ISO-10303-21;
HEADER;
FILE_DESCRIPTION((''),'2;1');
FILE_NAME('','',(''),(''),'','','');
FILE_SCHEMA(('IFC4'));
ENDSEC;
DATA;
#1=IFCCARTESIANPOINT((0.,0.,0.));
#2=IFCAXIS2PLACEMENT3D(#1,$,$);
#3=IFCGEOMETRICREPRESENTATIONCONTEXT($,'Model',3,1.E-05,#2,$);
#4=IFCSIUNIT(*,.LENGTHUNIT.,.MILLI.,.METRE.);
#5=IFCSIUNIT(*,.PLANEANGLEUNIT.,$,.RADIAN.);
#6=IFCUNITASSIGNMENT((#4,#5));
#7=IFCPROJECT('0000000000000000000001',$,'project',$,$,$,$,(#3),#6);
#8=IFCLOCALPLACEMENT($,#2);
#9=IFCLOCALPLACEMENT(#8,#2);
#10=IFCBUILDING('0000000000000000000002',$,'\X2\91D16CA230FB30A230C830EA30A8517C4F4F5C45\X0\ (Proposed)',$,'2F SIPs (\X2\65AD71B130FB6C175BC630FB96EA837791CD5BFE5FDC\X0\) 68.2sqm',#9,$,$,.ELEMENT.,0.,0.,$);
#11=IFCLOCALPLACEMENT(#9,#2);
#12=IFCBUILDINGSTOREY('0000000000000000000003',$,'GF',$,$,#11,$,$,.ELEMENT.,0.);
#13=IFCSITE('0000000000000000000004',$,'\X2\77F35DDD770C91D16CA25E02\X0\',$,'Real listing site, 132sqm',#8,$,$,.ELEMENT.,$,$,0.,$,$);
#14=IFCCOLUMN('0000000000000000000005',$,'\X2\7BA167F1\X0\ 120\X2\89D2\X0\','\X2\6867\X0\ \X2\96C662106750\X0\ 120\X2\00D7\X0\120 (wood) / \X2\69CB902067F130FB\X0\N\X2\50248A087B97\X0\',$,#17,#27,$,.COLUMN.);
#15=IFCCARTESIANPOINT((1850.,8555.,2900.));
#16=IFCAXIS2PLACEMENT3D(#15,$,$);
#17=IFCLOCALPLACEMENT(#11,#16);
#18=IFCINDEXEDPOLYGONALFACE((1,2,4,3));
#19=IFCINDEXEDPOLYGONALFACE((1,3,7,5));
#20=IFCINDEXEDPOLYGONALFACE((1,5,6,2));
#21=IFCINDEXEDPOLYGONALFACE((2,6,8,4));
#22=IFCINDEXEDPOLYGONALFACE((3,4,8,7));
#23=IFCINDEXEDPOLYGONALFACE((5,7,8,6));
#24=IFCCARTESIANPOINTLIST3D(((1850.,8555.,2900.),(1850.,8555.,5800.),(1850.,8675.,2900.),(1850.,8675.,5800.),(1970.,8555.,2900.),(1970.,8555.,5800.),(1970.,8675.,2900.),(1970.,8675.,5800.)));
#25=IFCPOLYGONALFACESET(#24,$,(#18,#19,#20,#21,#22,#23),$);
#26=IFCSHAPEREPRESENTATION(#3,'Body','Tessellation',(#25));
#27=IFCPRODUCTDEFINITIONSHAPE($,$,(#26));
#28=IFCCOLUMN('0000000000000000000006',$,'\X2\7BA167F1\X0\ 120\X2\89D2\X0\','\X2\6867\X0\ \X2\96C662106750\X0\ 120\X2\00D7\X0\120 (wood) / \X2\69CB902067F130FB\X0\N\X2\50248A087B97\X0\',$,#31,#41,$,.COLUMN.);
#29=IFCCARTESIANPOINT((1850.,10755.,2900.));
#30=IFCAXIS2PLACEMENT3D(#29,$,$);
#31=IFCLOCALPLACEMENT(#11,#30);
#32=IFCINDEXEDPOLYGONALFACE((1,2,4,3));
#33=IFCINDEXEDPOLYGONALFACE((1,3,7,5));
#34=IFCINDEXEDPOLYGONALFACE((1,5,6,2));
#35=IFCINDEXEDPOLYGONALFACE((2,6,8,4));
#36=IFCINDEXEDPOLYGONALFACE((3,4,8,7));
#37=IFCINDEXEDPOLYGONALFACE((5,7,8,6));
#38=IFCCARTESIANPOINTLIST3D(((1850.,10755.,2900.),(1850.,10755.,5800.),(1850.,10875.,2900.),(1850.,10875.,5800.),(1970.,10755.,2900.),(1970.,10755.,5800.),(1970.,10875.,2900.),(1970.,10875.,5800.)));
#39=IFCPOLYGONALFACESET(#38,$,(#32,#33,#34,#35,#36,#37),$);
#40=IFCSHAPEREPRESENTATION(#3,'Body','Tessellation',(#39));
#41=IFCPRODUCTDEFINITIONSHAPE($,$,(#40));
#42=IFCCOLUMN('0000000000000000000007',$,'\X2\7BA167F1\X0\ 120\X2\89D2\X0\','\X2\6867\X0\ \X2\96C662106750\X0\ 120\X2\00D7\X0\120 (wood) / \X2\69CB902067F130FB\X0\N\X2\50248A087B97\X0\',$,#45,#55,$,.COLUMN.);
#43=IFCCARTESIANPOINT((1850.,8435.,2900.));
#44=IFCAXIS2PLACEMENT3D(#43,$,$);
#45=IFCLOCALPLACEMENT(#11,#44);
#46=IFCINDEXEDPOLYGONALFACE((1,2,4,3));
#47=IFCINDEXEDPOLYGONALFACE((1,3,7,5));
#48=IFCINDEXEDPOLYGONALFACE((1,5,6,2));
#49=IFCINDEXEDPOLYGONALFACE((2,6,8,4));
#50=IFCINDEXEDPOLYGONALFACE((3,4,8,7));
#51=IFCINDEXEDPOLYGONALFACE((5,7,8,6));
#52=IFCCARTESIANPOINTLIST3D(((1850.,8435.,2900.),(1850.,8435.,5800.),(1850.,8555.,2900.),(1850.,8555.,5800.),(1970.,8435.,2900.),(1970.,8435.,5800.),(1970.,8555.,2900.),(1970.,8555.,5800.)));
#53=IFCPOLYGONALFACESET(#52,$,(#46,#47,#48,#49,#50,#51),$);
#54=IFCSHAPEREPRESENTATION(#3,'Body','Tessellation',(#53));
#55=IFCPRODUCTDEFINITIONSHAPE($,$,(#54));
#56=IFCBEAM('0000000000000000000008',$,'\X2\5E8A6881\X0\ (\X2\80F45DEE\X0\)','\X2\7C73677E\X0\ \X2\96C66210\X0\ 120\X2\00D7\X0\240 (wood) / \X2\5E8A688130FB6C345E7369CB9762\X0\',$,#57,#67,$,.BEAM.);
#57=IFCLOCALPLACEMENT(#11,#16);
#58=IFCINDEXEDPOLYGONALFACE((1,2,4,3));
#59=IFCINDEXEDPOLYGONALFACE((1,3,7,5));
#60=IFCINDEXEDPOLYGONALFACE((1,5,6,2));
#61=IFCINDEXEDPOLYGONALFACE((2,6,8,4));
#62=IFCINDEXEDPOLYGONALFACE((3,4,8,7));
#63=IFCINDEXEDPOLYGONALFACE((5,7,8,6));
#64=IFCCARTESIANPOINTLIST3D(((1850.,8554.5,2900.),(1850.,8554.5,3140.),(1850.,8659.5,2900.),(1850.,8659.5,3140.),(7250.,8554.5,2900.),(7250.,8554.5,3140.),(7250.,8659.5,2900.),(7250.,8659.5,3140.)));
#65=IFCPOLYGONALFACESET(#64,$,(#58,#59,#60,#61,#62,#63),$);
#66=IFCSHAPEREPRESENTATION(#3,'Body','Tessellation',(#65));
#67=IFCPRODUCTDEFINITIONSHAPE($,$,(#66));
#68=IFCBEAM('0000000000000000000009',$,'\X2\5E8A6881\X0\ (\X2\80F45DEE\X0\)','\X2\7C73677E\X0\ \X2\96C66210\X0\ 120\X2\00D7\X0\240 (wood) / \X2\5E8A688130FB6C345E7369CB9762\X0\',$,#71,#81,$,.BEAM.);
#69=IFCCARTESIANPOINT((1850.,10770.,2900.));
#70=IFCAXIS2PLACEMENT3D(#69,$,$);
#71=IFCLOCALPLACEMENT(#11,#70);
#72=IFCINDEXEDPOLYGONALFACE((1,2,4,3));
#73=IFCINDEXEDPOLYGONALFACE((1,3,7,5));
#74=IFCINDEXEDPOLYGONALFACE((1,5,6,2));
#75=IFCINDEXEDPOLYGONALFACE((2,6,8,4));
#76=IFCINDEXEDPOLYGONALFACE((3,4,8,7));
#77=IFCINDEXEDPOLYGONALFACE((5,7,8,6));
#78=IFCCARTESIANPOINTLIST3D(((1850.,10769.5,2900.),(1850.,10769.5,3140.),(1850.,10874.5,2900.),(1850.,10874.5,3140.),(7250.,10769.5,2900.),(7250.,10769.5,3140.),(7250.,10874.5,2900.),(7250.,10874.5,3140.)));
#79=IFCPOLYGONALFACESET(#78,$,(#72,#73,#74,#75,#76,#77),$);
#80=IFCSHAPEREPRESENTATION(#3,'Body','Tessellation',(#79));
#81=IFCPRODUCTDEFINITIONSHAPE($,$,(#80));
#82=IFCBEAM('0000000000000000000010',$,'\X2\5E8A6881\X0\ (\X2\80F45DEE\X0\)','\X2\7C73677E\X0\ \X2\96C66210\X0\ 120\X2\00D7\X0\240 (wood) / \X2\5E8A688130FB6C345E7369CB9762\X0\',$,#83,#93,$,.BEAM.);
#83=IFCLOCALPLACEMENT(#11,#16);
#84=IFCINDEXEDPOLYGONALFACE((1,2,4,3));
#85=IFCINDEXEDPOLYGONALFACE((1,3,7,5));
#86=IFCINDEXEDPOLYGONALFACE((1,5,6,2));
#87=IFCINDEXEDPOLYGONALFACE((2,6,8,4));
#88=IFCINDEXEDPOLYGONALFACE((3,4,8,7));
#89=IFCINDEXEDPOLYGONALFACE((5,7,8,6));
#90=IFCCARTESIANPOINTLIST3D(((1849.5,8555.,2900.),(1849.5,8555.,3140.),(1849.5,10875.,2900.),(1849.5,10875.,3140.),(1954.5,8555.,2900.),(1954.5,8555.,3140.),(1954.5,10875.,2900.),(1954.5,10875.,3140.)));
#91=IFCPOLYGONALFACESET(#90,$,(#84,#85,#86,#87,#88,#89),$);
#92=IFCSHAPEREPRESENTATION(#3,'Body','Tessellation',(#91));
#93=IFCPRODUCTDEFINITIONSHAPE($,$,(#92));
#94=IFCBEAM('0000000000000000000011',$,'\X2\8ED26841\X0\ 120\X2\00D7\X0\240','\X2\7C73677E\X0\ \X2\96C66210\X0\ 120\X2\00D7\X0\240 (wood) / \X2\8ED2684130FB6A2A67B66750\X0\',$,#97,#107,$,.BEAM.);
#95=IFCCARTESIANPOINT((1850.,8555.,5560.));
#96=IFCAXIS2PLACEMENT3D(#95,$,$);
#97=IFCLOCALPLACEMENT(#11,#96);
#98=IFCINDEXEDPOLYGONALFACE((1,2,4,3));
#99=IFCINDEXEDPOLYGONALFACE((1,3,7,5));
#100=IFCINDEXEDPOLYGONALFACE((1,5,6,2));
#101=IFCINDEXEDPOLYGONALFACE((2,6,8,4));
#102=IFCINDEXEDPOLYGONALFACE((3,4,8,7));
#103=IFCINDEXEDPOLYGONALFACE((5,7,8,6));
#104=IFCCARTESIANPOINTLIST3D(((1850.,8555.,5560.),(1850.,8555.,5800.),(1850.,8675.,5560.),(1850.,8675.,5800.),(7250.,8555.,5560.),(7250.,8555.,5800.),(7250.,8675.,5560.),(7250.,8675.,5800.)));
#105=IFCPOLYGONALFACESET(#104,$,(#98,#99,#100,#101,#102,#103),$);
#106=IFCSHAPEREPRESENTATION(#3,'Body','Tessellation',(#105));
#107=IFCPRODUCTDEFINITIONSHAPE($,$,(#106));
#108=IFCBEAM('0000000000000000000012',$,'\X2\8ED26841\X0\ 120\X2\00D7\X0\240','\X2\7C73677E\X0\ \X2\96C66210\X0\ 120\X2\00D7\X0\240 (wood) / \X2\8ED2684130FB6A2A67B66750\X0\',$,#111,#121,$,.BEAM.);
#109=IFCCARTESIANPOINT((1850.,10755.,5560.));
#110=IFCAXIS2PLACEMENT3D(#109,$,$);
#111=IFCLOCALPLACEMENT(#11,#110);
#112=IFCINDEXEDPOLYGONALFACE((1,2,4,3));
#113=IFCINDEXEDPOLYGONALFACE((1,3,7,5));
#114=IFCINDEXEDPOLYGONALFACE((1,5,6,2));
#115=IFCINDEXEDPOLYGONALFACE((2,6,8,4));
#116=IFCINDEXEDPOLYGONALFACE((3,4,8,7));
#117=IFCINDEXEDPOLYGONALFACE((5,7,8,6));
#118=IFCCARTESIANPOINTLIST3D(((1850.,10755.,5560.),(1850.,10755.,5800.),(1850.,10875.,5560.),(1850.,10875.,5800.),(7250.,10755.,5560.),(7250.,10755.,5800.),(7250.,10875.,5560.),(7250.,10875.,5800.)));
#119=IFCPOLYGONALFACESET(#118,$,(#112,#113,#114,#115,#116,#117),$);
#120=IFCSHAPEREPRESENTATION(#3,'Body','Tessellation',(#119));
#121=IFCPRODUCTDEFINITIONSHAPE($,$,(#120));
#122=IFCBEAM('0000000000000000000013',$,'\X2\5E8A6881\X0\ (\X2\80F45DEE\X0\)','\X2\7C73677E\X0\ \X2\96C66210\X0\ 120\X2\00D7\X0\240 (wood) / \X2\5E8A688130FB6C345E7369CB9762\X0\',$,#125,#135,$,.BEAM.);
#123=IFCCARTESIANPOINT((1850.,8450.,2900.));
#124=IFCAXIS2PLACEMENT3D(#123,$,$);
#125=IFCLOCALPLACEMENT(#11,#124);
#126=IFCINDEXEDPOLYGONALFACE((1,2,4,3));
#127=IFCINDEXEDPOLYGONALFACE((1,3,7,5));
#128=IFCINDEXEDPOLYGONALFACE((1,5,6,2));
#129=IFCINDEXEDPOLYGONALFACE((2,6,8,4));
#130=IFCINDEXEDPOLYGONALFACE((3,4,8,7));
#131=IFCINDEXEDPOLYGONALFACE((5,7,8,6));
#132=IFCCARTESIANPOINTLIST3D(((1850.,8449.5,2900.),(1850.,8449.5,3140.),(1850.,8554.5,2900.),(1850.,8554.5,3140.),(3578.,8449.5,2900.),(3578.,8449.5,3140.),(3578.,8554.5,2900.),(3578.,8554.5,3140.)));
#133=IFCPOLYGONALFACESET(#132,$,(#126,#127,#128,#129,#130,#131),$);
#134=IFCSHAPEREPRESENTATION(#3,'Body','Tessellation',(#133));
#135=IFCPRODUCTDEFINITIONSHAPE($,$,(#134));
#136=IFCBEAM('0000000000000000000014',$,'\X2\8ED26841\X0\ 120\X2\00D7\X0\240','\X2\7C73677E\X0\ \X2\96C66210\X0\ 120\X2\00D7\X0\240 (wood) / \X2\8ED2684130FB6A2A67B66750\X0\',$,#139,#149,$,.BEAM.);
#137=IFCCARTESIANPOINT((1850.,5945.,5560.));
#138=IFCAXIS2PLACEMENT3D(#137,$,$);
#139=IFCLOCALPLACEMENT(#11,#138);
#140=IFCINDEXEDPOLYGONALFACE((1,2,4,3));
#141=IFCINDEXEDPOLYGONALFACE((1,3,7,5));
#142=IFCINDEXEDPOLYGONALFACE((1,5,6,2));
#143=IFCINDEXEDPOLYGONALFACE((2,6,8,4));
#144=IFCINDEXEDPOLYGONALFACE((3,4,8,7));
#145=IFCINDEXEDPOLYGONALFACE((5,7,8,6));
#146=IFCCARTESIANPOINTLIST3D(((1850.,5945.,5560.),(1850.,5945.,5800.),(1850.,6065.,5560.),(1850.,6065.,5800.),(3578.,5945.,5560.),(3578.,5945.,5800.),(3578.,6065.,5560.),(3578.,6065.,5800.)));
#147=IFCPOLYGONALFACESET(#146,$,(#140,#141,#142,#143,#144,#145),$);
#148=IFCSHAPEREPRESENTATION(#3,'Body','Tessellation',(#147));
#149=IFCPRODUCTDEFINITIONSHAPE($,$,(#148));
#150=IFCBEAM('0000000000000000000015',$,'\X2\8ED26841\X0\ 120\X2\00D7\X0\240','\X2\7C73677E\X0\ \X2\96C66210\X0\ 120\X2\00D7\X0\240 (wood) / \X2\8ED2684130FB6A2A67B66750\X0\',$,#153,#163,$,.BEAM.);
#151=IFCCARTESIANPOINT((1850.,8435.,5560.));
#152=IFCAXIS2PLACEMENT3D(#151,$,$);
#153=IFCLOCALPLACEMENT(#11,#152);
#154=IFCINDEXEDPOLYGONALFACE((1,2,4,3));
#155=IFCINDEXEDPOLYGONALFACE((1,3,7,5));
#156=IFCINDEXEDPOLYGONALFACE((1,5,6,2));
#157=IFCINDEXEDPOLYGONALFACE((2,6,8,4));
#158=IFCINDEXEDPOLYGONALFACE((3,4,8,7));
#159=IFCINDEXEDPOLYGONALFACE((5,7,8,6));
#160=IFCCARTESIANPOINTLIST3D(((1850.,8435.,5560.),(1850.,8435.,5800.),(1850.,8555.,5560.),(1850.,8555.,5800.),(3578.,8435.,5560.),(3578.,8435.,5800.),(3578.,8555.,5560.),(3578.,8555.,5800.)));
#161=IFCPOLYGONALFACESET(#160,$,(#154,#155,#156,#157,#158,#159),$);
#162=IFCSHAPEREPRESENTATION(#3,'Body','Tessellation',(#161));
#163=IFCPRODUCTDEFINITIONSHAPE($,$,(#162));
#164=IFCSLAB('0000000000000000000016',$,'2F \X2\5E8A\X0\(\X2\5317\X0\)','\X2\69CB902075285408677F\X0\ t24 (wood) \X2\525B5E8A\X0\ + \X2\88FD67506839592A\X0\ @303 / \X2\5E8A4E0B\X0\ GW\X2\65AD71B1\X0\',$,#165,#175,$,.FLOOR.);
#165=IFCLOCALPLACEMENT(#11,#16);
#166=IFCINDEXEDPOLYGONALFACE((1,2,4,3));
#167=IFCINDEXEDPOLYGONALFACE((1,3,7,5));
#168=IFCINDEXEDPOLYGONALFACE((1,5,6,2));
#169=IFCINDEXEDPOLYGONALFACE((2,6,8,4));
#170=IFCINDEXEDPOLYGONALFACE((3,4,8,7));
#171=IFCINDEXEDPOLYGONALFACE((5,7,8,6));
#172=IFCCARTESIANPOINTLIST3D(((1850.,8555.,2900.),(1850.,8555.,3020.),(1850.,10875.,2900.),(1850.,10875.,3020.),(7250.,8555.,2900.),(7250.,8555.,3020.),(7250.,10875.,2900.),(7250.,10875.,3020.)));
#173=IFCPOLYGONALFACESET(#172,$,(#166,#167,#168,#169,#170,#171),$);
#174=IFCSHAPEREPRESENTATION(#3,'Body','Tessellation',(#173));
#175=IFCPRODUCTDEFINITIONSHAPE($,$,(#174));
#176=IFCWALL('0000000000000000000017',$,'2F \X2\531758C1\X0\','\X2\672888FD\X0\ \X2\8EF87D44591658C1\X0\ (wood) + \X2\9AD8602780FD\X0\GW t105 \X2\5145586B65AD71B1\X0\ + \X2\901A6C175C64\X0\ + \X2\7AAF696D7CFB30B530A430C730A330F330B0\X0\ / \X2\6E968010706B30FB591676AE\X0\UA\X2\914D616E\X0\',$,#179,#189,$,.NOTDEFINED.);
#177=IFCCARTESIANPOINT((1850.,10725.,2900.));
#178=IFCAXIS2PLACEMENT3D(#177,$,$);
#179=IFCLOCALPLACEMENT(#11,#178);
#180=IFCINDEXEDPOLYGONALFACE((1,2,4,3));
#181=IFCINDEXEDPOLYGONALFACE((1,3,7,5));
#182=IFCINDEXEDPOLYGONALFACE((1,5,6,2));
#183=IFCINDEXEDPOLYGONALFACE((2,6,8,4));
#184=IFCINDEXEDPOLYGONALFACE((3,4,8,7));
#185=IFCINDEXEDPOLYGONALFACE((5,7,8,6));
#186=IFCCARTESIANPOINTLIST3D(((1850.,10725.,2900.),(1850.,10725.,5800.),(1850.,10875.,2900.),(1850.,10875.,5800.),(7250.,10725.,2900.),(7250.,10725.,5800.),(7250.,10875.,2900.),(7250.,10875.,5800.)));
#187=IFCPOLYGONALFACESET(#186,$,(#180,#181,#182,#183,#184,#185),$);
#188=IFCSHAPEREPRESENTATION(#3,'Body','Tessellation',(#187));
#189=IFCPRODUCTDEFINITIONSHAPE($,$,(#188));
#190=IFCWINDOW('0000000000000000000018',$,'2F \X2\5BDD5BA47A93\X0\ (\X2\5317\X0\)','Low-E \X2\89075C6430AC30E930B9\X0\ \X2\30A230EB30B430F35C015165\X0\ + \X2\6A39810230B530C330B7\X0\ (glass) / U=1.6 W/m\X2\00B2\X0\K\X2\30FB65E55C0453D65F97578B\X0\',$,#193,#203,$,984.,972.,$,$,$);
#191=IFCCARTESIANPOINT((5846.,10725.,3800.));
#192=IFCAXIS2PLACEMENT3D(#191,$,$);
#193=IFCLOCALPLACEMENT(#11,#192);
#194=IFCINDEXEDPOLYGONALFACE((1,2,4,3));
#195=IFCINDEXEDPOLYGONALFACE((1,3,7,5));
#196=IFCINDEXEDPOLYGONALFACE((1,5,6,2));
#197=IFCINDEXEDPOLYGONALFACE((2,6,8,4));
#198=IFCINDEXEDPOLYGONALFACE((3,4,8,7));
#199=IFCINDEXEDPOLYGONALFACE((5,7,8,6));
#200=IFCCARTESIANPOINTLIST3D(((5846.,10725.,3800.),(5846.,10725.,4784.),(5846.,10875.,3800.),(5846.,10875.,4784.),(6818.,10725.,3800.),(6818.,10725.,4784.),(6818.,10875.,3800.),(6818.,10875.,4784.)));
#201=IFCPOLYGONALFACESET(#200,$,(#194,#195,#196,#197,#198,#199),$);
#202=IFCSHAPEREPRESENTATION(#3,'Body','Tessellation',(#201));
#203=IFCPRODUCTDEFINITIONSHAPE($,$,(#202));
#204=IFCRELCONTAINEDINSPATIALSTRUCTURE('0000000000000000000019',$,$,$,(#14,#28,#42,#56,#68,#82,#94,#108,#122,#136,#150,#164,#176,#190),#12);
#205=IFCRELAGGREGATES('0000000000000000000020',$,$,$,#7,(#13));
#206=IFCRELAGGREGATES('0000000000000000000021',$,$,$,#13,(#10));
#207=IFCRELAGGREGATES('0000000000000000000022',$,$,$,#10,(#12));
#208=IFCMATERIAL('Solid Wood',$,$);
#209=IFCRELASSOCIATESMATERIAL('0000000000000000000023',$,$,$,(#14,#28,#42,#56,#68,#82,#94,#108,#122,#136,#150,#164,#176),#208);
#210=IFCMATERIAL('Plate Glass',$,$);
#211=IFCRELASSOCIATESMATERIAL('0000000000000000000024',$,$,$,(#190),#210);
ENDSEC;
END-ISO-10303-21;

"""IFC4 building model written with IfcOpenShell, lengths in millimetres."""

from ifc_helpers import new_model, si_unit, frame, frame_2d, origin, place, context, project, spatial, rectangle, extrude, material, element, fill, save


model = new_model("IFC4")

# Units and contexts
model_context = context("Model", 3, precision=1e-05, world=origin())
ifc_project = project(units=[si_unit("LENGTHUNIT", "METRE", prefix="MILLI"), si_unit("PLANEANGLEUNIT", "RADIAN")], contexts=[model_context])

# Site, building, storey
site_placement = place(None, origin())
site = spatial("IfcSite", under=ifc_project, at=site_placement, Name="石川県金沢市", ObjectType="Real listing site, 132sqm", CompositionType="ELEMENT", RefElevation=0.0)
building_placement = place(site_placement, origin())
building = spatial("IfcBuilding", under=site, at=building_placement, Name="金沢・アトリエ兼住居 (Proposed)", ObjectType="2F SIPs (断熱・気密・雪荷重対応) 68.2sqm", CompositionType="ELEMENT", ElevationOfRefHeight=0.0, ElevationOfTerrain=0.0)
storey_placement = place(building_placement, origin())
storey = spatial("IfcBuildingStorey", under=building, at=storey_placement, Name="GF", CompositionType="ELEMENT", Elevation=0.0)

# Columns
ifc_material_1 = material(Name="Solid Wood")
column_1_placement = place(storey_placement, frame((1850.0, 8555.0, 2900.0)))
element("IfcColumn", 1, at=column_1_placement, inside=storey, material=ifc_material_1, Name="管柱 120角", Description="桧 集成材 120×120 (wood) / 構造柱・N値計算", PredefinedType="COLUMN", context=model_context, shape_type="SweptSolid", body=[
    extrude(rectangle(XDim=120.0, YDim=120.0, at=frame_2d((60.0, 60.0))), frame((1850.0, 8555.0, 2900.0)), (0.0, 0.0, 1.0), 2900.0),
])
column_2_placement = place(storey_placement, frame((1850.0, 10755.0, 2900.0)))
element("IfcColumn", 2, at=column_2_placement, inside=storey, material=ifc_material_1, Name="管柱 120角", Description="桧 集成材 120×120 (wood) / 構造柱・N値計算", PredefinedType="COLUMN", context=model_context, shape_type="SweptSolid", body=[
    extrude(rectangle(XDim=120.0, YDim=120.0, at=frame_2d((60.0, 60.0))), frame((1850.0, 10755.0, 2900.0)), (0.0, 0.0, 1.0), 2900.0),
])
column_3_placement = place(storey_placement, frame((1850.0, 8435.0, 2900.0)))
element("IfcColumn", 3, at=column_3_placement, inside=storey, material=ifc_material_1, Name="管柱 120角", Description="桧 集成材 120×120 (wood) / 構造柱・N値計算", PredefinedType="COLUMN", context=model_context, shape_type="SweptSolid", body=[
    extrude(rectangle(XDim=120.0, YDim=120.0, at=frame_2d((60.0, 60.0))), frame((1850.0, 8435.0, 2900.0)), (0.0, 0.0, 1.0), 2900.0),
])

# Beams
beam_1_placement = place(storey_placement, frame((1850.0, 8555.0, 2900.0)))
element("IfcBeam", 4, at=beam_1_placement, inside=storey, material=ifc_material_1, Name="床梁 (胴差)", Description="米松 集成 120×240 (wood) / 床梁・水平構面", PredefinedType="BEAM", context=model_context, shape_type="SweptSolid", body=[
    extrude(rectangle(XDim=5400.0, YDim=105.0, at=frame_2d((2700.0, 52.0))), frame((1850.0, 8555.0, 2900.0)), (0.0, 0.0, 1.0), 240.0),
])
beam_2_placement = place(storey_placement, frame((1850.0, 10770.0, 2900.0)))
element("IfcBeam", 5, at=beam_2_placement, inside=storey, material=ifc_material_1, Name="床梁 (胴差)", Description="米松 集成 120×240 (wood) / 床梁・水平構面", PredefinedType="BEAM", context=model_context, shape_type="SweptSolid", body=[
    extrude(rectangle(XDim=5400.0, YDim=105.0, at=frame_2d((2700.0, 52.0))), frame((1850.0, 10770.0, 2900.0)), (0.0, 0.0, 1.0), 240.0),
])
beam_3_placement = place(storey_placement, frame((1850.0, 8555.0, 2900.0)))
element("IfcBeam", 6, at=beam_3_placement, inside=storey, material=ifc_material_1, Name="床梁 (胴差)", Description="米松 集成 120×240 (wood) / 床梁・水平構面", PredefinedType="BEAM", context=model_context, shape_type="SweptSolid", body=[
    extrude(rectangle(XDim=105.0, YDim=2320.0, at=frame_2d((52.0, 1160.0))), frame((1850.0, 8555.0, 2900.0)), (0.0, 0.0, 1.0), 240.0),
])
beam_4_placement = place(storey_placement, frame((1850.0, 8555.0, 5560.0)))
element("IfcBeam", 7, at=beam_4_placement, inside=storey, material=ifc_material_1, Name="軒桁 120×240", Description="米松 集成 120×240 (wood) / 軒桁・横架材", PredefinedType="BEAM", context=model_context, shape_type="SweptSolid", body=[
    extrude(rectangle(XDim=5400.0, YDim=120.0, at=frame_2d((2700.0, 60.0))), frame((1850.0, 8555.0, 5560.0)), (0.0, 0.0, 1.0), 240.0),
])
beam_5_placement = place(storey_placement, frame((1850.0, 10755.0, 5560.0)))
element("IfcBeam", 8, at=beam_5_placement, inside=storey, material=ifc_material_1, Name="軒桁 120×240", Description="米松 集成 120×240 (wood) / 軒桁・横架材", PredefinedType="BEAM", context=model_context, shape_type="SweptSolid", body=[
    extrude(rectangle(XDim=5400.0, YDim=120.0, at=frame_2d((2700.0, 60.0))), frame((1850.0, 10755.0, 5560.0)), (0.0, 0.0, 1.0), 240.0),
])
beam_6_placement = place(storey_placement, frame((1850.0, 8450.0, 2900.0)))
element("IfcBeam", 9, at=beam_6_placement, inside=storey, material=ifc_material_1, Name="床梁 (胴差)", Description="米松 集成 120×240 (wood) / 床梁・水平構面", PredefinedType="BEAM", context=model_context, shape_type="SweptSolid", body=[
    extrude(rectangle(XDim=1728.0, YDim=105.0, at=frame_2d((864.0, 52.0))), frame((1850.0, 8450.0, 2900.0)), (0.0, 0.0, 1.0), 240.0),
])
beam_7_placement = place(storey_placement, frame((1850.0, 5945.0, 5560.0)))
element("IfcBeam", 10, at=beam_7_placement, inside=storey, material=ifc_material_1, Name="軒桁 120×240", Description="米松 集成 120×240 (wood) / 軒桁・横架材", PredefinedType="BEAM", context=model_context, shape_type="SweptSolid", body=[
    extrude(rectangle(XDim=1728.0, YDim=120.0, at=frame_2d((864.0, 60.0))), frame((1850.0, 5945.0, 5560.0)), (0.0, 0.0, 1.0), 240.0),
])
beam_8_placement = place(storey_placement, frame((1850.0, 8435.0, 5560.0)))
element("IfcBeam", 11, at=beam_8_placement, inside=storey, material=ifc_material_1, Name="軒桁 120×240", Description="米松 集成 120×240 (wood) / 軒桁・横架材", PredefinedType="BEAM", context=model_context, shape_type="SweptSolid", body=[
    extrude(rectangle(XDim=1728.0, YDim=120.0, at=frame_2d((864.0, 60.0))), frame((1850.0, 8435.0, 5560.0)), (0.0, 0.0, 1.0), 240.0),
])

# Slab
slab_placement = place(storey_placement, frame((1850.0, 8555.0, 2900.0)))
element("IfcSlab", 12, at=slab_placement, inside=storey, material=ifc_material_1, Name="2F 床(北)", Description="構造用合板 t24 (wood) 剛床 + 製材根太 @303 / 床下 GW断熱", PredefinedType="FLOOR", context=model_context, shape_type="SweptSolid", body=[
    extrude(rectangle(XDim=5400.0, YDim=2320.0, at=frame_2d((2700.0, 1160.0))), frame((1850.0, 8555.0, 2900.0)), (0.0, 0.0, 1.0), 120.0),
])

# Wall, opening, window
wall_placement = place(storey_placement, frame((1850.0, 10725.0, 2900.0)))
wall = element("IfcWall", 13, at=wall_placement, inside=storey, material=ifc_material_1, Name="2F 北壁", Description="木製 軸組外壁 (wood) + 高性能GW t105 充填断熱 + 通気層 + 窯業系サイディング / 準耐火・外皮UA配慮", PredefinedType="NOTDEFINED", context=model_context, shape_type="SweptSolid", body=[
    extrude(rectangle(XDim=5400.0, YDim=150.0, at=frame_2d((2700.0, 75.0))), frame((1850.0, 10725.0, 2900.0)), (0.0, 0.0, 1.0), 2900.0),
])
opening_placement = place(storey_placement, frame((5846.0, 10725.0, 3800.0)))
opening = element("IfcOpeningElement", 14, at=opening_placement, cuts=wall, PredefinedType="NOTDEFINED", context=model_context, shape_type="SweptSolid", body=[
    extrude(rectangle(XDim=972.0, YDim=150.0, at=frame_2d((486.0, 75.0))), frame((5846.0, 10725.0, 3800.0)), (0.0, 0.0, 1.0), 984.0),
])
ifc_material_2 = material(Name="Plate Glass")
window_placement = place(storey_placement, frame((5846.0, 10725.0, 3800.0)))
window = element("IfcWindow", 15, at=window_placement, inside=storey, material=ifc_material_2, Name="2F 寝室窓 (北)", Description="Low-E 複層ガラス アルゴン封入 + 樹脂サッシ (glass) / U=1.6 W/m²K・日射取得型", OverallHeight=984.0, OverallWidth=972.0, context=model_context, shape_type="SweptSolid", body=[
    extrude(rectangle(XDim=972.0, YDim=150.0, at=frame_2d((486.0, 75.0))), frame((5846.0, 10725.0, 3800.0)), (0.0, 0.0, 1.0), 984.0),
])
fill(opening, window)

save(model, "model.ifc")
